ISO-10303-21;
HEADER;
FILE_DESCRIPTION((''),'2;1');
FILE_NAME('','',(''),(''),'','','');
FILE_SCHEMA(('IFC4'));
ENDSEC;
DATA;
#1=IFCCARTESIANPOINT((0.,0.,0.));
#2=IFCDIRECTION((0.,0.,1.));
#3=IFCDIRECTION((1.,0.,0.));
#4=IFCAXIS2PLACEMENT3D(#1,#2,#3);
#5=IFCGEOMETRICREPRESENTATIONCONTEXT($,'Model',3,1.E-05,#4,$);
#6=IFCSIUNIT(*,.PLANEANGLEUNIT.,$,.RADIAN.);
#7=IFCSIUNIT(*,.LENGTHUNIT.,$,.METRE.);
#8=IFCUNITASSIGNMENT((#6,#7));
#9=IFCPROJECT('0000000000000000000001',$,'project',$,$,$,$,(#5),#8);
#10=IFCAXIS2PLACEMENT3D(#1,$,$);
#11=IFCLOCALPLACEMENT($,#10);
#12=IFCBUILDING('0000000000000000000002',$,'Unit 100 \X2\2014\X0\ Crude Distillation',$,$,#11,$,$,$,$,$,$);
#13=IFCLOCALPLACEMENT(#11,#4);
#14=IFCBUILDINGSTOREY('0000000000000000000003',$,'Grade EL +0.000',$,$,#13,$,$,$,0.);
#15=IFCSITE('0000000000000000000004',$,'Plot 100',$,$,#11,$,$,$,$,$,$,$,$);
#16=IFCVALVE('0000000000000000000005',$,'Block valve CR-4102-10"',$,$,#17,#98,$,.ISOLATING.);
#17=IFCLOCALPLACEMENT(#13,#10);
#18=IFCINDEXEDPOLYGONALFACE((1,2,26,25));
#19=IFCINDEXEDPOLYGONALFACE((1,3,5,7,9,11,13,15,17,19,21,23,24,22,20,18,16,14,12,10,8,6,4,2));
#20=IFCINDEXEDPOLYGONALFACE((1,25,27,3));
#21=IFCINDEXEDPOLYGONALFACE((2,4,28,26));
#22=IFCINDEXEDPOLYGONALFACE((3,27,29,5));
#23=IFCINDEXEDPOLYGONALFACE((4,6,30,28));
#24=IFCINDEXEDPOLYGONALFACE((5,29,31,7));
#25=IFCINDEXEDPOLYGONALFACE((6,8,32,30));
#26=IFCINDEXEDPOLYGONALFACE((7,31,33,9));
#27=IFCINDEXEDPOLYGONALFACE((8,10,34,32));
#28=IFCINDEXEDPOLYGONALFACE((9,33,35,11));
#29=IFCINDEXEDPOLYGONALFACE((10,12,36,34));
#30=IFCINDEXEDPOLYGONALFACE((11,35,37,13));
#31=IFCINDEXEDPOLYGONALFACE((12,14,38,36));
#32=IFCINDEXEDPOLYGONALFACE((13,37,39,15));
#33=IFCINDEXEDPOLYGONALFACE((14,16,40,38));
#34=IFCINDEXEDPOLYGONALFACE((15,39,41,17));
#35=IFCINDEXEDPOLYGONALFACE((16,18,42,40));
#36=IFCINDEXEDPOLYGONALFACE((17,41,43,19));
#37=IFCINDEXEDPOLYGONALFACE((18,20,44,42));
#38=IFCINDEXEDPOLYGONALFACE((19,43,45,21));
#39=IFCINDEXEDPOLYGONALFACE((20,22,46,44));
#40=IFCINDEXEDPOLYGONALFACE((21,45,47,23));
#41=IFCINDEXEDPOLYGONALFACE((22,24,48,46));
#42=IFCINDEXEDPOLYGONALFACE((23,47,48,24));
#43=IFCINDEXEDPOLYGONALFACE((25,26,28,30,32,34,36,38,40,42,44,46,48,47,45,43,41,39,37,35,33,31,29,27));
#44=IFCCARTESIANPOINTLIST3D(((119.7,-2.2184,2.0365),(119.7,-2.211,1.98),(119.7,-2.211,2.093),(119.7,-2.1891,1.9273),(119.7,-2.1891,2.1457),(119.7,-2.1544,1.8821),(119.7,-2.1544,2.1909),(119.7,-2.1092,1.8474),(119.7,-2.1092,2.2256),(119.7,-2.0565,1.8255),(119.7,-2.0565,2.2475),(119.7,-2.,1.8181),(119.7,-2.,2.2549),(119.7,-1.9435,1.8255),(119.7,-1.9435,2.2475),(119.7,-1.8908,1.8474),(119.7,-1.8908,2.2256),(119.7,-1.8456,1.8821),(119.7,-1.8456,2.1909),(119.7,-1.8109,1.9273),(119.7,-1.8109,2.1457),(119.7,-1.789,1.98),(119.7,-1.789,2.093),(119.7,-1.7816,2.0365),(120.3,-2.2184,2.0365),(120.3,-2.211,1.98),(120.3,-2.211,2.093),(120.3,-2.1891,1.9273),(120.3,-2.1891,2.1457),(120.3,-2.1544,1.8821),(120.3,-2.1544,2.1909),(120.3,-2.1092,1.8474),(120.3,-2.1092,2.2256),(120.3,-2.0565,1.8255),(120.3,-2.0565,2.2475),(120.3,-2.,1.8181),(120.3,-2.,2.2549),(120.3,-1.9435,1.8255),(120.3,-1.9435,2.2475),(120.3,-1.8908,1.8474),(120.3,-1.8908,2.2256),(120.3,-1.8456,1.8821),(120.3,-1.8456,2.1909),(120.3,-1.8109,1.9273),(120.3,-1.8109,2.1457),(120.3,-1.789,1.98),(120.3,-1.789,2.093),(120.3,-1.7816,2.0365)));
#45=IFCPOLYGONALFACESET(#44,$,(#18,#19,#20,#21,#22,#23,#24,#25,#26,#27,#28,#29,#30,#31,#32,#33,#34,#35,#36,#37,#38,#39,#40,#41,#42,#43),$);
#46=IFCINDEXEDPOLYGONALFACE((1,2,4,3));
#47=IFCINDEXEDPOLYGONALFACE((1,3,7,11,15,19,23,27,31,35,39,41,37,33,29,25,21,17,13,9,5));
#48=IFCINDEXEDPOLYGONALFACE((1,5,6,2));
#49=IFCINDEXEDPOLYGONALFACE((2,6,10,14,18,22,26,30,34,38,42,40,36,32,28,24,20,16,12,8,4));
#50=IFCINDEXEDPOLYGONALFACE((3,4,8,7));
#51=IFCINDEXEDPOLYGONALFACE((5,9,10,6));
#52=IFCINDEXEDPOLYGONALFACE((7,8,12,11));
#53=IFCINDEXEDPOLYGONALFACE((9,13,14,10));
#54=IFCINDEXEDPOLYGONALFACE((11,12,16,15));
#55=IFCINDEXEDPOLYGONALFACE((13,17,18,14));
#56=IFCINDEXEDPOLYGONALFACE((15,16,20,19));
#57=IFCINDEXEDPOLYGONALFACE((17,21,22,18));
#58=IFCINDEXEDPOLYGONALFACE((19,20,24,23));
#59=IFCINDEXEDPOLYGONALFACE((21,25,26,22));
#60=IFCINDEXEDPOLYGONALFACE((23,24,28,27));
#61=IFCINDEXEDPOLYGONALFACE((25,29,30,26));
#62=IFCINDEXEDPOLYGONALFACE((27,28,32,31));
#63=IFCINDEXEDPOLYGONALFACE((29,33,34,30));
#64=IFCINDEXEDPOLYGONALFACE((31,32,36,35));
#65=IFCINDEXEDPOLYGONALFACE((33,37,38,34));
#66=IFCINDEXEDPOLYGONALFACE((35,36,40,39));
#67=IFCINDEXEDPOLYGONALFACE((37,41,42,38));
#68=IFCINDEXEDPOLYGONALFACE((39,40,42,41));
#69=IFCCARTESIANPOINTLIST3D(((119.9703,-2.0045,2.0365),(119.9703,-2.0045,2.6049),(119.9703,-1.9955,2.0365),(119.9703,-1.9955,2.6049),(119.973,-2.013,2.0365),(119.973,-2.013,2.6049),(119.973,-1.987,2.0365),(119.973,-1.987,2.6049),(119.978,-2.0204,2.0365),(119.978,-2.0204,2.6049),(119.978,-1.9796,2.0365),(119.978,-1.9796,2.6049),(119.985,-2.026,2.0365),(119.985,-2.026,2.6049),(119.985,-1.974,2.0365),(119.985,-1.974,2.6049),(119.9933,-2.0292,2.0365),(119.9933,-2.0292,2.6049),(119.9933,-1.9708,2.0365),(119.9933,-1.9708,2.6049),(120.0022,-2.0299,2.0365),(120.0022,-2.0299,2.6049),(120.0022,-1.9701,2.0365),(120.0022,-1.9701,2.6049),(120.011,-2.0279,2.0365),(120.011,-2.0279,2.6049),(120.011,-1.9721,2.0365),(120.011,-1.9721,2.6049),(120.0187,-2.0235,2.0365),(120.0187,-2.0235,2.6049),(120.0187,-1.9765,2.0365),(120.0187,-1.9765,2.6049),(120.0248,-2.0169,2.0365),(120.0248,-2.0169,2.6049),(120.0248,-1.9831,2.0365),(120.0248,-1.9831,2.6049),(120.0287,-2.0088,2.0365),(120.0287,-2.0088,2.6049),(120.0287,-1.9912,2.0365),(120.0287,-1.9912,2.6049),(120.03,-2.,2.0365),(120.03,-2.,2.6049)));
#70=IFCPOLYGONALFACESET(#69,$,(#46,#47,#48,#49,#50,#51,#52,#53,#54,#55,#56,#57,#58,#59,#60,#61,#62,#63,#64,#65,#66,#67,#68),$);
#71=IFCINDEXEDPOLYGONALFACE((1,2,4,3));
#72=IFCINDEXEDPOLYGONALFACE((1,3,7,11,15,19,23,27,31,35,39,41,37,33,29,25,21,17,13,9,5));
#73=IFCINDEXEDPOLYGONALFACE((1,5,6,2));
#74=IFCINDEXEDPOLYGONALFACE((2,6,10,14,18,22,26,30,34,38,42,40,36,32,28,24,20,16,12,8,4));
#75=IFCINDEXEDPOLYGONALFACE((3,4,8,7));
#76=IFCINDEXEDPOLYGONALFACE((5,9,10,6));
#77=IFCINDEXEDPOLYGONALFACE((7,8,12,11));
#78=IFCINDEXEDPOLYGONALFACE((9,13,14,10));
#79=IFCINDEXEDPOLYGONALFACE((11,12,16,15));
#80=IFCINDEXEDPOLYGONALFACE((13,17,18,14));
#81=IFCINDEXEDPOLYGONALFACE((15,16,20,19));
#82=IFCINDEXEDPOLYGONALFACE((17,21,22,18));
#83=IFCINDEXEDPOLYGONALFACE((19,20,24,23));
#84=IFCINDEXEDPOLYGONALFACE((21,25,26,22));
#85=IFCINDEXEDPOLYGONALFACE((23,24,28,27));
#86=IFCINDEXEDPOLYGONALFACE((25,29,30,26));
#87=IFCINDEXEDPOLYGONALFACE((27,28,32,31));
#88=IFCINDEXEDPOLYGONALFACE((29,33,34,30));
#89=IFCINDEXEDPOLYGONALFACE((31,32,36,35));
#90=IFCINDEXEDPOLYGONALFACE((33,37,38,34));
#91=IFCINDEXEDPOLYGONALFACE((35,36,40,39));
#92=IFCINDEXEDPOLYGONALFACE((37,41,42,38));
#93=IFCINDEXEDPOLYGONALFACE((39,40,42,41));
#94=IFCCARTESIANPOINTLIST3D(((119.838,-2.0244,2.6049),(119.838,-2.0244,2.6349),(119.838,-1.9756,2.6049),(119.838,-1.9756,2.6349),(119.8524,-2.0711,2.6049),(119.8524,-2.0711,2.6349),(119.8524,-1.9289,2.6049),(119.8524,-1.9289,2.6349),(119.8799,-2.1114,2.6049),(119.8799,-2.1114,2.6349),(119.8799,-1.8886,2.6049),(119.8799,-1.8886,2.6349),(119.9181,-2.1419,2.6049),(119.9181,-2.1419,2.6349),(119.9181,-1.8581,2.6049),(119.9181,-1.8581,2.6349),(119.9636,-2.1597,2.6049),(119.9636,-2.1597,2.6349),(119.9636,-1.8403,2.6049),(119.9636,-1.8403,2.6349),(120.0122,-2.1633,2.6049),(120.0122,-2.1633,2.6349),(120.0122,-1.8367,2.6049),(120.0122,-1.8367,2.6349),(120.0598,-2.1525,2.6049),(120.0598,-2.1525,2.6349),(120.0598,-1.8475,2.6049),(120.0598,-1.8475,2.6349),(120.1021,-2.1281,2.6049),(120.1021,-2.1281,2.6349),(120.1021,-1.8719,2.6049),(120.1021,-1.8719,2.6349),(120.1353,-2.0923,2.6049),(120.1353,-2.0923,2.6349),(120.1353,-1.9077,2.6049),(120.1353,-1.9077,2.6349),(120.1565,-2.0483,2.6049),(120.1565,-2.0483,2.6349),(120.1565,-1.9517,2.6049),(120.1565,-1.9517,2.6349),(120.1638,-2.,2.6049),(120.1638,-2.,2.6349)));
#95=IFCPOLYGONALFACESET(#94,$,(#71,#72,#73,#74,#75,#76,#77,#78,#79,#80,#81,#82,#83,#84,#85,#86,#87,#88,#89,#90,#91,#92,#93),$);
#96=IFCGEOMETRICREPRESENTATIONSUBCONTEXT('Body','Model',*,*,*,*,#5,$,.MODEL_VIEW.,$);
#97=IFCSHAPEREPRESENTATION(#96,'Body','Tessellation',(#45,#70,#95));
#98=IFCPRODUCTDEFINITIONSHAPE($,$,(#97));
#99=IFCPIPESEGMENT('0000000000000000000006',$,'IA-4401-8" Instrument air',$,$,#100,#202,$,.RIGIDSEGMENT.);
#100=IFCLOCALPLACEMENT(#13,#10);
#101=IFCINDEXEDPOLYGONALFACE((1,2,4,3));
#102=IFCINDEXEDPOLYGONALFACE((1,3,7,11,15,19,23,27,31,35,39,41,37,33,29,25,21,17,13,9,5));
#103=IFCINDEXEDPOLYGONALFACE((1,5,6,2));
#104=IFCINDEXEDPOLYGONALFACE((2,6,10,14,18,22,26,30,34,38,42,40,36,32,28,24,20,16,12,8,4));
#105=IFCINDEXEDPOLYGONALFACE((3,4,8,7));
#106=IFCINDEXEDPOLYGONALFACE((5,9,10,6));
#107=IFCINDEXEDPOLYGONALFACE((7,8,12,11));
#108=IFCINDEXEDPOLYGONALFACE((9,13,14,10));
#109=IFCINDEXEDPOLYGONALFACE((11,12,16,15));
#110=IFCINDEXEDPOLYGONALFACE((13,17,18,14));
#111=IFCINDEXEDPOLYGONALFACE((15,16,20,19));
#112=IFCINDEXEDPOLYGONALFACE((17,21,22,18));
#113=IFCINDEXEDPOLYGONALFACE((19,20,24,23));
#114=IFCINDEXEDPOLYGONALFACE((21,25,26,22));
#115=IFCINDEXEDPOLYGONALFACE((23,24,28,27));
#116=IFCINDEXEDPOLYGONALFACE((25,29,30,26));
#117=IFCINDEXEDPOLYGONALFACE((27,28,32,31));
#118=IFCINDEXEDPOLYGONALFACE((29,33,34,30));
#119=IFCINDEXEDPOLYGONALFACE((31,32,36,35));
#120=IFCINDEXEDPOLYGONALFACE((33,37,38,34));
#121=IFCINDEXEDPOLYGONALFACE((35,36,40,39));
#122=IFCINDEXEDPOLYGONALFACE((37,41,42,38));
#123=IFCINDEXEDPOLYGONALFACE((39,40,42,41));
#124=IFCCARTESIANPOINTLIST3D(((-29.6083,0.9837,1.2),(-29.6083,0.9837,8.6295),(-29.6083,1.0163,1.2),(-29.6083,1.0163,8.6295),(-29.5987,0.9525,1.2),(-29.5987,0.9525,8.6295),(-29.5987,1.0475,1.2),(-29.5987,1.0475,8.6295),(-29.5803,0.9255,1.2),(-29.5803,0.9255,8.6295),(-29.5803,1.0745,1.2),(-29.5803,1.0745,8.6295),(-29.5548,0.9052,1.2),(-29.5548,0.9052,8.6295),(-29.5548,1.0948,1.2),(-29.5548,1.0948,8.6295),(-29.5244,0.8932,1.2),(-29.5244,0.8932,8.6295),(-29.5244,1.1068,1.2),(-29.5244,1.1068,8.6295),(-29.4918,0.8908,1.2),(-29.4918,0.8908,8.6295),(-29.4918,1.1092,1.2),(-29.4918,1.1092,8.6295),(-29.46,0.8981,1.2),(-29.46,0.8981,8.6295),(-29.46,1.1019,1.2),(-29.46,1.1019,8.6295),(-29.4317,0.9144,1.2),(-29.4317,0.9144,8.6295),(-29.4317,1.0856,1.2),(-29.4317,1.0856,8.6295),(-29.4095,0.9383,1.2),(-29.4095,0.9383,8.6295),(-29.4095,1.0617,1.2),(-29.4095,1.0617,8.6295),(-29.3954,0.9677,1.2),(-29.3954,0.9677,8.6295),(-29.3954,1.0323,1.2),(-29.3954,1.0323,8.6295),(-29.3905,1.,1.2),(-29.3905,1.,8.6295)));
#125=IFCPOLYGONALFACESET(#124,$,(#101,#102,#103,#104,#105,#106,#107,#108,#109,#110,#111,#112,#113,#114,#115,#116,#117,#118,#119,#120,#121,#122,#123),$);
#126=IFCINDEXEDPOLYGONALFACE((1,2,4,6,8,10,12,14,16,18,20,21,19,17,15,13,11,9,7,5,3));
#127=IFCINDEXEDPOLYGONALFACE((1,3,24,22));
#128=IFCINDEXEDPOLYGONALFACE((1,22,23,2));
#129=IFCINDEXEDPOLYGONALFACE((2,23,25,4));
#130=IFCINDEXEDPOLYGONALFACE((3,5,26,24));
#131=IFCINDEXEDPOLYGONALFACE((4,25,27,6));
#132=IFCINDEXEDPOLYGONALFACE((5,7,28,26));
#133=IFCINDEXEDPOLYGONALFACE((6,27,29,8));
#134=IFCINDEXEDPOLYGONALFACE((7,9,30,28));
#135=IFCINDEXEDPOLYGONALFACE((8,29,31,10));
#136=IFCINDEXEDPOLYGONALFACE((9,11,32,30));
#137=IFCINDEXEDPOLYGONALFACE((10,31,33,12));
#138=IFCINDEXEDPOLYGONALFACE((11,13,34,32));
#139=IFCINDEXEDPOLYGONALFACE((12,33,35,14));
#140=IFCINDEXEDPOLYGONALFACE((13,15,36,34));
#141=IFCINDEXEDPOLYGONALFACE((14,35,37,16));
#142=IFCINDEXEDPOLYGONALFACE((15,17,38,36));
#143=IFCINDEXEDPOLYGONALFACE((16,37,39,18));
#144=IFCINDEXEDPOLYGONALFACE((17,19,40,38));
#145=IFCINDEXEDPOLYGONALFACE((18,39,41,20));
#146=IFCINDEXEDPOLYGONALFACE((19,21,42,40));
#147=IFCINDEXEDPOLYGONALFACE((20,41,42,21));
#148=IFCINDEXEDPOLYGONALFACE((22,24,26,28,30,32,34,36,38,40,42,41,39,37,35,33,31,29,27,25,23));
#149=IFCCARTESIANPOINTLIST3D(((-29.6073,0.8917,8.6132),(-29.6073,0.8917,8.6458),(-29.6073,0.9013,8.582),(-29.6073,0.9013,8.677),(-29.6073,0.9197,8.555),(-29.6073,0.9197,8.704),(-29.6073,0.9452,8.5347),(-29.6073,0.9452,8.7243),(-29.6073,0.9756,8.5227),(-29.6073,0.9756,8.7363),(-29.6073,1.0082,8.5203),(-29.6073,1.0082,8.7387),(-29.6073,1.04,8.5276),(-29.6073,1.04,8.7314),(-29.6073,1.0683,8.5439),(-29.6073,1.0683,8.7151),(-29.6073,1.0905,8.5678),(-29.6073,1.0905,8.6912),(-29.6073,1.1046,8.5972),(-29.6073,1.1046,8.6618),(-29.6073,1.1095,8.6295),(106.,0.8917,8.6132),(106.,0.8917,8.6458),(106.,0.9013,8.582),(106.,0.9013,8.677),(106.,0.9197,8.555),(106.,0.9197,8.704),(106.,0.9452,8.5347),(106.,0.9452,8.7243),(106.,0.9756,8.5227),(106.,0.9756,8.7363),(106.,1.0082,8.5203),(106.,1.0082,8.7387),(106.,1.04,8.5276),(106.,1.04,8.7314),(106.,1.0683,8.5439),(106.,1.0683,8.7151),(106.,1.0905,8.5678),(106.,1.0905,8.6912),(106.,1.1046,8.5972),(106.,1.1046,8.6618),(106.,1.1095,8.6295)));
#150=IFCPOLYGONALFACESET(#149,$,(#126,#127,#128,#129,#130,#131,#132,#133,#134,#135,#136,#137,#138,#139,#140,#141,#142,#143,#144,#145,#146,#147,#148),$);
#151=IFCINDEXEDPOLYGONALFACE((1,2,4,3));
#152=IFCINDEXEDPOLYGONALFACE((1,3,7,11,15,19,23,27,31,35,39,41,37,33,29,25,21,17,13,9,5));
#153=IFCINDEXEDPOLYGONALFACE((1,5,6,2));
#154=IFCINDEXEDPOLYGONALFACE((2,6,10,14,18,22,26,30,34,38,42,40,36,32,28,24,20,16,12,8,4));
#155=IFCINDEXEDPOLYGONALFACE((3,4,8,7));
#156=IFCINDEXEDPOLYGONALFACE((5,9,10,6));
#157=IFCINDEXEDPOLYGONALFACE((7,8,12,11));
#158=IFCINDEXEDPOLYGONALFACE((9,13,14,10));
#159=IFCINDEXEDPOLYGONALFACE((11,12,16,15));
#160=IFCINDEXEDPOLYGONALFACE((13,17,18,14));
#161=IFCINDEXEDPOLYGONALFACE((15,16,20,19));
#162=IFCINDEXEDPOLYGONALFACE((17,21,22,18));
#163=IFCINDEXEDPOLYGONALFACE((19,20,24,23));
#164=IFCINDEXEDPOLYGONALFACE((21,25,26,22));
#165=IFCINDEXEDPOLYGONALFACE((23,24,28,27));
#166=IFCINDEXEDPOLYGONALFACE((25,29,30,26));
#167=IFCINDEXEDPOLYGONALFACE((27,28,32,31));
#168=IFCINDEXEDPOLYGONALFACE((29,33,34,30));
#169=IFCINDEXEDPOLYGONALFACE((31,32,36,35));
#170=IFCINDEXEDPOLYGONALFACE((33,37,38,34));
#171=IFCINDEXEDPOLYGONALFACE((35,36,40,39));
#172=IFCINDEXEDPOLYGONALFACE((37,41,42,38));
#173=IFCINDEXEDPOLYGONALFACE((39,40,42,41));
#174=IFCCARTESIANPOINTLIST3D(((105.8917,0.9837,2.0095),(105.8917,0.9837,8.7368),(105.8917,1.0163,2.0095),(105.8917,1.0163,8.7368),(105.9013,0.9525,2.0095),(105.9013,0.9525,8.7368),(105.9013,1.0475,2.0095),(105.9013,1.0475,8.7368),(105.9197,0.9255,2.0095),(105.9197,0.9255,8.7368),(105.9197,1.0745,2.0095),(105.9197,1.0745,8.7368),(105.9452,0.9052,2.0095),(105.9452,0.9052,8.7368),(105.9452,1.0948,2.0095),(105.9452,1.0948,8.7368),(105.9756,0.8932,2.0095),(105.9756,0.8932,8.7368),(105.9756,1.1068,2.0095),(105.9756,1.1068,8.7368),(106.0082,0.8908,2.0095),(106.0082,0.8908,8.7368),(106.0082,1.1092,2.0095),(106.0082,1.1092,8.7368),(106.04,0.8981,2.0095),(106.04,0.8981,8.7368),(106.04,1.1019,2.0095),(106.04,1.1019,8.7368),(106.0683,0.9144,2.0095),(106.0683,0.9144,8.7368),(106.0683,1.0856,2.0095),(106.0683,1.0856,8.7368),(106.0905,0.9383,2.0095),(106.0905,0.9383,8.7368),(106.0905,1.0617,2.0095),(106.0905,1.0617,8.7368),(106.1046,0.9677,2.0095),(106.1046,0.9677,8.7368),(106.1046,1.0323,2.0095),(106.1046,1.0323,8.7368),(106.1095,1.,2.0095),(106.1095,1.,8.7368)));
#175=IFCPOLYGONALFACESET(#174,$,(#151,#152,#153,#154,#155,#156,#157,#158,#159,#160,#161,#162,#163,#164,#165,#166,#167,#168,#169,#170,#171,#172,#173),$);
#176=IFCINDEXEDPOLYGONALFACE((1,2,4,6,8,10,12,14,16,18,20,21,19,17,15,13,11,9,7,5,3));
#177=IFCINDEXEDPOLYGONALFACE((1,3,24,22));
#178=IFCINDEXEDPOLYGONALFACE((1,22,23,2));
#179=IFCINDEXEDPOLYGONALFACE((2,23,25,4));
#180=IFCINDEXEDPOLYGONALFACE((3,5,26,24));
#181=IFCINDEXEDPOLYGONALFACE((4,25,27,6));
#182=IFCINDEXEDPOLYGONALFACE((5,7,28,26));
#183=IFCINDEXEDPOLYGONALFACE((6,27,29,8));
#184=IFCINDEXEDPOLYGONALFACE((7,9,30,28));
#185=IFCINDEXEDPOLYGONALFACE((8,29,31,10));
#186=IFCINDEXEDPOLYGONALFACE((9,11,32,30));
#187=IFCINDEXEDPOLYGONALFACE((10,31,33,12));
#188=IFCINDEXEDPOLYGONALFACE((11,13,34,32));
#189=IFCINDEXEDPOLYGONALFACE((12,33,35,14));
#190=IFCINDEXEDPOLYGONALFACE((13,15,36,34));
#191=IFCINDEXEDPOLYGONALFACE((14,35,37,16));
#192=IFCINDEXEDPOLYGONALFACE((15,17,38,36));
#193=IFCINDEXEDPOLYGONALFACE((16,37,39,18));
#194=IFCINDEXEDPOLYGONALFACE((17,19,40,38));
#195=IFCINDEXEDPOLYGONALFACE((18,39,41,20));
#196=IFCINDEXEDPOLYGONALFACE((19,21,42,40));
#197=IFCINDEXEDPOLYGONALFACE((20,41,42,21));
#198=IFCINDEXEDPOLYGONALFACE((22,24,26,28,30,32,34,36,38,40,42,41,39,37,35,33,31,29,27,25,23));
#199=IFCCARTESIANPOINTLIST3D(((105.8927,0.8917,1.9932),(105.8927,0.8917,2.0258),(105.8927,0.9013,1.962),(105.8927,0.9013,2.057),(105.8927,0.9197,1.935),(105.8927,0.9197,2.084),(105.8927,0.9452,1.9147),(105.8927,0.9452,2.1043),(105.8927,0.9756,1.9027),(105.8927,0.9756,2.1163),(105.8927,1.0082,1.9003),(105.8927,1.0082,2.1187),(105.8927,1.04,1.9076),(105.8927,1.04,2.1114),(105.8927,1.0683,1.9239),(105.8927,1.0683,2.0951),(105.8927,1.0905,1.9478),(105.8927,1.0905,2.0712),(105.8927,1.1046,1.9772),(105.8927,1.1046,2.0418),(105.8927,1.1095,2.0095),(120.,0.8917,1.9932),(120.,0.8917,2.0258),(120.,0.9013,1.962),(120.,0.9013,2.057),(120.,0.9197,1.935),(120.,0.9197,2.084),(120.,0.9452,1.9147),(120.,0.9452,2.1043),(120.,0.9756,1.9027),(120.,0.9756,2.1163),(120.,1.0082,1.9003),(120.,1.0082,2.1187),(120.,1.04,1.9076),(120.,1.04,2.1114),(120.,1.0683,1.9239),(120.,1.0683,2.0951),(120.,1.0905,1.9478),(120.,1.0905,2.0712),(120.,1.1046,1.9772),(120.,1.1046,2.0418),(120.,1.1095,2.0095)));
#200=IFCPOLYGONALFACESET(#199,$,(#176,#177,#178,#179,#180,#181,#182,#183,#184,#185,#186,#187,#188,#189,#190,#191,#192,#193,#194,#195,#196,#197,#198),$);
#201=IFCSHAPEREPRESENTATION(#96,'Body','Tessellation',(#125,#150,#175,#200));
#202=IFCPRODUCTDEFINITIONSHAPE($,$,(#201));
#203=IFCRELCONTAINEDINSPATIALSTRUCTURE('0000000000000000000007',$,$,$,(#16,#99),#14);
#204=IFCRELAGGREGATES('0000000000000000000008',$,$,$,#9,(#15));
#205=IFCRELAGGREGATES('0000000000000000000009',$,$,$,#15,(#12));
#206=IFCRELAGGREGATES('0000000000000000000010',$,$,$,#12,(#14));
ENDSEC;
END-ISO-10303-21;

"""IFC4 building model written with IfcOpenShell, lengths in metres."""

from ifc_helpers import new_model, si_unit, frame, origin, origin_with_axes, origin_2d, place, context, subcontext, project, spatial, circle, extrude, element, save


model = new_model("IFC4")

# Units and contexts
model_context = context("Model", 3, precision=1e-05, world=origin_with_axes())
body_context = subcontext(model_context, "Body", "Model", "MODEL_VIEW")
ifc_project = project(units=[si_unit("PLANEANGLEUNIT", "RADIAN"), si_unit("LENGTHUNIT", "METRE")], contexts=[model_context])

# Site, building, storey
placement = place(None, origin())
site = spatial("IfcSite", under=ifc_project, at=placement, Name="Plot 100")
building = spatial("IfcBuilding", under=site, at=placement, Name="Unit 100 — Crude Distillation")
storey_placement = place(placement, origin_with_axes())
storey = spatial("IfcBuildingStorey", under=building, at=storey_placement, Name="Grade EL +0.000", Elevation=0.0)

# Valve
valve_1_placement = place(storey_placement, origin_with_axes())
element("IfcValve", 1, at=valve_1_placement, inside=storey, Name="Block valve CR-4102-10\"", PredefinedType="ISOLATING", context=body_context, shape_type="SweptSolid", body=[
    extrude(circle(Radius=0.2184, at=origin_2d()), frame((119.7, -2.0, 2.0365), z_axis=(1.0, 0.0, 0.0), x_axis=(0.0, 1.0, 0.0)), (0.0, 0.0, 1.0), 0.6),
    extrude(circle(Radius=0.03, at=origin_2d()), frame((120.0, -2.0, 2.0365), z_axis=(0.0, 0.0, 1.0), x_axis=(1.0, 0.0, 0.0)), (0.0, 0.0, 1.0), 0.5684),
    extrude(circle(Radius=0.1638, at=origin_2d()), frame((120.0, -2.0, 2.6049), z_axis=(0.0, 0.0, 1.0), x_axis=(1.0, 0.0, 0.0)), (0.0, 0.0, 1.0), 0.03),
])

# Pipe segment
pipe_segment_1_placement = place(storey_placement, origin_with_axes())
element("IfcPipeSegment", 2, at=pipe_segment_1_placement, inside=storey, Name="IA-4401-8\" Instrument air", PredefinedType="RIGIDSEGMENT", context=body_context, shape_type="SweptSolid", body=[
    extrude(circle(Radius=0.1095, at=origin_2d()), frame((-29.5, 1.0, 1.2), z_axis=(0.0, 0.0, 1.0), x_axis=(1.0, 0.0, 0.0)), (0.0, 0.0, 1.0), 7.4295),
    extrude(circle(Radius=0.1095, at=origin_2d()), frame((-29.6073, 1.0, 8.6295), z_axis=(1.0, 0.0, 0.0), x_axis=(0.0, 1.0, 0.0)), (0.0, 0.0, 1.0), 135.6073),
    extrude(circle(Radius=0.1095, at=origin_2d()), frame((106.0, 1.0, 8.7368), z_axis=(0.0, 0.0, -1.0), x_axis=(1.0, 0.0, 0.0)), (0.0, 0.0, 1.0), 6.7273),
    extrude(circle(Radius=0.1095, at=origin_2d()), frame((105.8927, 1.0, 2.0095), z_axis=(1.0, 0.0, 0.0), x_axis=(0.0, 1.0, 0.0)), (0.0, 0.0, 1.0), 14.1073),
])

save(model, "model.ifc")
